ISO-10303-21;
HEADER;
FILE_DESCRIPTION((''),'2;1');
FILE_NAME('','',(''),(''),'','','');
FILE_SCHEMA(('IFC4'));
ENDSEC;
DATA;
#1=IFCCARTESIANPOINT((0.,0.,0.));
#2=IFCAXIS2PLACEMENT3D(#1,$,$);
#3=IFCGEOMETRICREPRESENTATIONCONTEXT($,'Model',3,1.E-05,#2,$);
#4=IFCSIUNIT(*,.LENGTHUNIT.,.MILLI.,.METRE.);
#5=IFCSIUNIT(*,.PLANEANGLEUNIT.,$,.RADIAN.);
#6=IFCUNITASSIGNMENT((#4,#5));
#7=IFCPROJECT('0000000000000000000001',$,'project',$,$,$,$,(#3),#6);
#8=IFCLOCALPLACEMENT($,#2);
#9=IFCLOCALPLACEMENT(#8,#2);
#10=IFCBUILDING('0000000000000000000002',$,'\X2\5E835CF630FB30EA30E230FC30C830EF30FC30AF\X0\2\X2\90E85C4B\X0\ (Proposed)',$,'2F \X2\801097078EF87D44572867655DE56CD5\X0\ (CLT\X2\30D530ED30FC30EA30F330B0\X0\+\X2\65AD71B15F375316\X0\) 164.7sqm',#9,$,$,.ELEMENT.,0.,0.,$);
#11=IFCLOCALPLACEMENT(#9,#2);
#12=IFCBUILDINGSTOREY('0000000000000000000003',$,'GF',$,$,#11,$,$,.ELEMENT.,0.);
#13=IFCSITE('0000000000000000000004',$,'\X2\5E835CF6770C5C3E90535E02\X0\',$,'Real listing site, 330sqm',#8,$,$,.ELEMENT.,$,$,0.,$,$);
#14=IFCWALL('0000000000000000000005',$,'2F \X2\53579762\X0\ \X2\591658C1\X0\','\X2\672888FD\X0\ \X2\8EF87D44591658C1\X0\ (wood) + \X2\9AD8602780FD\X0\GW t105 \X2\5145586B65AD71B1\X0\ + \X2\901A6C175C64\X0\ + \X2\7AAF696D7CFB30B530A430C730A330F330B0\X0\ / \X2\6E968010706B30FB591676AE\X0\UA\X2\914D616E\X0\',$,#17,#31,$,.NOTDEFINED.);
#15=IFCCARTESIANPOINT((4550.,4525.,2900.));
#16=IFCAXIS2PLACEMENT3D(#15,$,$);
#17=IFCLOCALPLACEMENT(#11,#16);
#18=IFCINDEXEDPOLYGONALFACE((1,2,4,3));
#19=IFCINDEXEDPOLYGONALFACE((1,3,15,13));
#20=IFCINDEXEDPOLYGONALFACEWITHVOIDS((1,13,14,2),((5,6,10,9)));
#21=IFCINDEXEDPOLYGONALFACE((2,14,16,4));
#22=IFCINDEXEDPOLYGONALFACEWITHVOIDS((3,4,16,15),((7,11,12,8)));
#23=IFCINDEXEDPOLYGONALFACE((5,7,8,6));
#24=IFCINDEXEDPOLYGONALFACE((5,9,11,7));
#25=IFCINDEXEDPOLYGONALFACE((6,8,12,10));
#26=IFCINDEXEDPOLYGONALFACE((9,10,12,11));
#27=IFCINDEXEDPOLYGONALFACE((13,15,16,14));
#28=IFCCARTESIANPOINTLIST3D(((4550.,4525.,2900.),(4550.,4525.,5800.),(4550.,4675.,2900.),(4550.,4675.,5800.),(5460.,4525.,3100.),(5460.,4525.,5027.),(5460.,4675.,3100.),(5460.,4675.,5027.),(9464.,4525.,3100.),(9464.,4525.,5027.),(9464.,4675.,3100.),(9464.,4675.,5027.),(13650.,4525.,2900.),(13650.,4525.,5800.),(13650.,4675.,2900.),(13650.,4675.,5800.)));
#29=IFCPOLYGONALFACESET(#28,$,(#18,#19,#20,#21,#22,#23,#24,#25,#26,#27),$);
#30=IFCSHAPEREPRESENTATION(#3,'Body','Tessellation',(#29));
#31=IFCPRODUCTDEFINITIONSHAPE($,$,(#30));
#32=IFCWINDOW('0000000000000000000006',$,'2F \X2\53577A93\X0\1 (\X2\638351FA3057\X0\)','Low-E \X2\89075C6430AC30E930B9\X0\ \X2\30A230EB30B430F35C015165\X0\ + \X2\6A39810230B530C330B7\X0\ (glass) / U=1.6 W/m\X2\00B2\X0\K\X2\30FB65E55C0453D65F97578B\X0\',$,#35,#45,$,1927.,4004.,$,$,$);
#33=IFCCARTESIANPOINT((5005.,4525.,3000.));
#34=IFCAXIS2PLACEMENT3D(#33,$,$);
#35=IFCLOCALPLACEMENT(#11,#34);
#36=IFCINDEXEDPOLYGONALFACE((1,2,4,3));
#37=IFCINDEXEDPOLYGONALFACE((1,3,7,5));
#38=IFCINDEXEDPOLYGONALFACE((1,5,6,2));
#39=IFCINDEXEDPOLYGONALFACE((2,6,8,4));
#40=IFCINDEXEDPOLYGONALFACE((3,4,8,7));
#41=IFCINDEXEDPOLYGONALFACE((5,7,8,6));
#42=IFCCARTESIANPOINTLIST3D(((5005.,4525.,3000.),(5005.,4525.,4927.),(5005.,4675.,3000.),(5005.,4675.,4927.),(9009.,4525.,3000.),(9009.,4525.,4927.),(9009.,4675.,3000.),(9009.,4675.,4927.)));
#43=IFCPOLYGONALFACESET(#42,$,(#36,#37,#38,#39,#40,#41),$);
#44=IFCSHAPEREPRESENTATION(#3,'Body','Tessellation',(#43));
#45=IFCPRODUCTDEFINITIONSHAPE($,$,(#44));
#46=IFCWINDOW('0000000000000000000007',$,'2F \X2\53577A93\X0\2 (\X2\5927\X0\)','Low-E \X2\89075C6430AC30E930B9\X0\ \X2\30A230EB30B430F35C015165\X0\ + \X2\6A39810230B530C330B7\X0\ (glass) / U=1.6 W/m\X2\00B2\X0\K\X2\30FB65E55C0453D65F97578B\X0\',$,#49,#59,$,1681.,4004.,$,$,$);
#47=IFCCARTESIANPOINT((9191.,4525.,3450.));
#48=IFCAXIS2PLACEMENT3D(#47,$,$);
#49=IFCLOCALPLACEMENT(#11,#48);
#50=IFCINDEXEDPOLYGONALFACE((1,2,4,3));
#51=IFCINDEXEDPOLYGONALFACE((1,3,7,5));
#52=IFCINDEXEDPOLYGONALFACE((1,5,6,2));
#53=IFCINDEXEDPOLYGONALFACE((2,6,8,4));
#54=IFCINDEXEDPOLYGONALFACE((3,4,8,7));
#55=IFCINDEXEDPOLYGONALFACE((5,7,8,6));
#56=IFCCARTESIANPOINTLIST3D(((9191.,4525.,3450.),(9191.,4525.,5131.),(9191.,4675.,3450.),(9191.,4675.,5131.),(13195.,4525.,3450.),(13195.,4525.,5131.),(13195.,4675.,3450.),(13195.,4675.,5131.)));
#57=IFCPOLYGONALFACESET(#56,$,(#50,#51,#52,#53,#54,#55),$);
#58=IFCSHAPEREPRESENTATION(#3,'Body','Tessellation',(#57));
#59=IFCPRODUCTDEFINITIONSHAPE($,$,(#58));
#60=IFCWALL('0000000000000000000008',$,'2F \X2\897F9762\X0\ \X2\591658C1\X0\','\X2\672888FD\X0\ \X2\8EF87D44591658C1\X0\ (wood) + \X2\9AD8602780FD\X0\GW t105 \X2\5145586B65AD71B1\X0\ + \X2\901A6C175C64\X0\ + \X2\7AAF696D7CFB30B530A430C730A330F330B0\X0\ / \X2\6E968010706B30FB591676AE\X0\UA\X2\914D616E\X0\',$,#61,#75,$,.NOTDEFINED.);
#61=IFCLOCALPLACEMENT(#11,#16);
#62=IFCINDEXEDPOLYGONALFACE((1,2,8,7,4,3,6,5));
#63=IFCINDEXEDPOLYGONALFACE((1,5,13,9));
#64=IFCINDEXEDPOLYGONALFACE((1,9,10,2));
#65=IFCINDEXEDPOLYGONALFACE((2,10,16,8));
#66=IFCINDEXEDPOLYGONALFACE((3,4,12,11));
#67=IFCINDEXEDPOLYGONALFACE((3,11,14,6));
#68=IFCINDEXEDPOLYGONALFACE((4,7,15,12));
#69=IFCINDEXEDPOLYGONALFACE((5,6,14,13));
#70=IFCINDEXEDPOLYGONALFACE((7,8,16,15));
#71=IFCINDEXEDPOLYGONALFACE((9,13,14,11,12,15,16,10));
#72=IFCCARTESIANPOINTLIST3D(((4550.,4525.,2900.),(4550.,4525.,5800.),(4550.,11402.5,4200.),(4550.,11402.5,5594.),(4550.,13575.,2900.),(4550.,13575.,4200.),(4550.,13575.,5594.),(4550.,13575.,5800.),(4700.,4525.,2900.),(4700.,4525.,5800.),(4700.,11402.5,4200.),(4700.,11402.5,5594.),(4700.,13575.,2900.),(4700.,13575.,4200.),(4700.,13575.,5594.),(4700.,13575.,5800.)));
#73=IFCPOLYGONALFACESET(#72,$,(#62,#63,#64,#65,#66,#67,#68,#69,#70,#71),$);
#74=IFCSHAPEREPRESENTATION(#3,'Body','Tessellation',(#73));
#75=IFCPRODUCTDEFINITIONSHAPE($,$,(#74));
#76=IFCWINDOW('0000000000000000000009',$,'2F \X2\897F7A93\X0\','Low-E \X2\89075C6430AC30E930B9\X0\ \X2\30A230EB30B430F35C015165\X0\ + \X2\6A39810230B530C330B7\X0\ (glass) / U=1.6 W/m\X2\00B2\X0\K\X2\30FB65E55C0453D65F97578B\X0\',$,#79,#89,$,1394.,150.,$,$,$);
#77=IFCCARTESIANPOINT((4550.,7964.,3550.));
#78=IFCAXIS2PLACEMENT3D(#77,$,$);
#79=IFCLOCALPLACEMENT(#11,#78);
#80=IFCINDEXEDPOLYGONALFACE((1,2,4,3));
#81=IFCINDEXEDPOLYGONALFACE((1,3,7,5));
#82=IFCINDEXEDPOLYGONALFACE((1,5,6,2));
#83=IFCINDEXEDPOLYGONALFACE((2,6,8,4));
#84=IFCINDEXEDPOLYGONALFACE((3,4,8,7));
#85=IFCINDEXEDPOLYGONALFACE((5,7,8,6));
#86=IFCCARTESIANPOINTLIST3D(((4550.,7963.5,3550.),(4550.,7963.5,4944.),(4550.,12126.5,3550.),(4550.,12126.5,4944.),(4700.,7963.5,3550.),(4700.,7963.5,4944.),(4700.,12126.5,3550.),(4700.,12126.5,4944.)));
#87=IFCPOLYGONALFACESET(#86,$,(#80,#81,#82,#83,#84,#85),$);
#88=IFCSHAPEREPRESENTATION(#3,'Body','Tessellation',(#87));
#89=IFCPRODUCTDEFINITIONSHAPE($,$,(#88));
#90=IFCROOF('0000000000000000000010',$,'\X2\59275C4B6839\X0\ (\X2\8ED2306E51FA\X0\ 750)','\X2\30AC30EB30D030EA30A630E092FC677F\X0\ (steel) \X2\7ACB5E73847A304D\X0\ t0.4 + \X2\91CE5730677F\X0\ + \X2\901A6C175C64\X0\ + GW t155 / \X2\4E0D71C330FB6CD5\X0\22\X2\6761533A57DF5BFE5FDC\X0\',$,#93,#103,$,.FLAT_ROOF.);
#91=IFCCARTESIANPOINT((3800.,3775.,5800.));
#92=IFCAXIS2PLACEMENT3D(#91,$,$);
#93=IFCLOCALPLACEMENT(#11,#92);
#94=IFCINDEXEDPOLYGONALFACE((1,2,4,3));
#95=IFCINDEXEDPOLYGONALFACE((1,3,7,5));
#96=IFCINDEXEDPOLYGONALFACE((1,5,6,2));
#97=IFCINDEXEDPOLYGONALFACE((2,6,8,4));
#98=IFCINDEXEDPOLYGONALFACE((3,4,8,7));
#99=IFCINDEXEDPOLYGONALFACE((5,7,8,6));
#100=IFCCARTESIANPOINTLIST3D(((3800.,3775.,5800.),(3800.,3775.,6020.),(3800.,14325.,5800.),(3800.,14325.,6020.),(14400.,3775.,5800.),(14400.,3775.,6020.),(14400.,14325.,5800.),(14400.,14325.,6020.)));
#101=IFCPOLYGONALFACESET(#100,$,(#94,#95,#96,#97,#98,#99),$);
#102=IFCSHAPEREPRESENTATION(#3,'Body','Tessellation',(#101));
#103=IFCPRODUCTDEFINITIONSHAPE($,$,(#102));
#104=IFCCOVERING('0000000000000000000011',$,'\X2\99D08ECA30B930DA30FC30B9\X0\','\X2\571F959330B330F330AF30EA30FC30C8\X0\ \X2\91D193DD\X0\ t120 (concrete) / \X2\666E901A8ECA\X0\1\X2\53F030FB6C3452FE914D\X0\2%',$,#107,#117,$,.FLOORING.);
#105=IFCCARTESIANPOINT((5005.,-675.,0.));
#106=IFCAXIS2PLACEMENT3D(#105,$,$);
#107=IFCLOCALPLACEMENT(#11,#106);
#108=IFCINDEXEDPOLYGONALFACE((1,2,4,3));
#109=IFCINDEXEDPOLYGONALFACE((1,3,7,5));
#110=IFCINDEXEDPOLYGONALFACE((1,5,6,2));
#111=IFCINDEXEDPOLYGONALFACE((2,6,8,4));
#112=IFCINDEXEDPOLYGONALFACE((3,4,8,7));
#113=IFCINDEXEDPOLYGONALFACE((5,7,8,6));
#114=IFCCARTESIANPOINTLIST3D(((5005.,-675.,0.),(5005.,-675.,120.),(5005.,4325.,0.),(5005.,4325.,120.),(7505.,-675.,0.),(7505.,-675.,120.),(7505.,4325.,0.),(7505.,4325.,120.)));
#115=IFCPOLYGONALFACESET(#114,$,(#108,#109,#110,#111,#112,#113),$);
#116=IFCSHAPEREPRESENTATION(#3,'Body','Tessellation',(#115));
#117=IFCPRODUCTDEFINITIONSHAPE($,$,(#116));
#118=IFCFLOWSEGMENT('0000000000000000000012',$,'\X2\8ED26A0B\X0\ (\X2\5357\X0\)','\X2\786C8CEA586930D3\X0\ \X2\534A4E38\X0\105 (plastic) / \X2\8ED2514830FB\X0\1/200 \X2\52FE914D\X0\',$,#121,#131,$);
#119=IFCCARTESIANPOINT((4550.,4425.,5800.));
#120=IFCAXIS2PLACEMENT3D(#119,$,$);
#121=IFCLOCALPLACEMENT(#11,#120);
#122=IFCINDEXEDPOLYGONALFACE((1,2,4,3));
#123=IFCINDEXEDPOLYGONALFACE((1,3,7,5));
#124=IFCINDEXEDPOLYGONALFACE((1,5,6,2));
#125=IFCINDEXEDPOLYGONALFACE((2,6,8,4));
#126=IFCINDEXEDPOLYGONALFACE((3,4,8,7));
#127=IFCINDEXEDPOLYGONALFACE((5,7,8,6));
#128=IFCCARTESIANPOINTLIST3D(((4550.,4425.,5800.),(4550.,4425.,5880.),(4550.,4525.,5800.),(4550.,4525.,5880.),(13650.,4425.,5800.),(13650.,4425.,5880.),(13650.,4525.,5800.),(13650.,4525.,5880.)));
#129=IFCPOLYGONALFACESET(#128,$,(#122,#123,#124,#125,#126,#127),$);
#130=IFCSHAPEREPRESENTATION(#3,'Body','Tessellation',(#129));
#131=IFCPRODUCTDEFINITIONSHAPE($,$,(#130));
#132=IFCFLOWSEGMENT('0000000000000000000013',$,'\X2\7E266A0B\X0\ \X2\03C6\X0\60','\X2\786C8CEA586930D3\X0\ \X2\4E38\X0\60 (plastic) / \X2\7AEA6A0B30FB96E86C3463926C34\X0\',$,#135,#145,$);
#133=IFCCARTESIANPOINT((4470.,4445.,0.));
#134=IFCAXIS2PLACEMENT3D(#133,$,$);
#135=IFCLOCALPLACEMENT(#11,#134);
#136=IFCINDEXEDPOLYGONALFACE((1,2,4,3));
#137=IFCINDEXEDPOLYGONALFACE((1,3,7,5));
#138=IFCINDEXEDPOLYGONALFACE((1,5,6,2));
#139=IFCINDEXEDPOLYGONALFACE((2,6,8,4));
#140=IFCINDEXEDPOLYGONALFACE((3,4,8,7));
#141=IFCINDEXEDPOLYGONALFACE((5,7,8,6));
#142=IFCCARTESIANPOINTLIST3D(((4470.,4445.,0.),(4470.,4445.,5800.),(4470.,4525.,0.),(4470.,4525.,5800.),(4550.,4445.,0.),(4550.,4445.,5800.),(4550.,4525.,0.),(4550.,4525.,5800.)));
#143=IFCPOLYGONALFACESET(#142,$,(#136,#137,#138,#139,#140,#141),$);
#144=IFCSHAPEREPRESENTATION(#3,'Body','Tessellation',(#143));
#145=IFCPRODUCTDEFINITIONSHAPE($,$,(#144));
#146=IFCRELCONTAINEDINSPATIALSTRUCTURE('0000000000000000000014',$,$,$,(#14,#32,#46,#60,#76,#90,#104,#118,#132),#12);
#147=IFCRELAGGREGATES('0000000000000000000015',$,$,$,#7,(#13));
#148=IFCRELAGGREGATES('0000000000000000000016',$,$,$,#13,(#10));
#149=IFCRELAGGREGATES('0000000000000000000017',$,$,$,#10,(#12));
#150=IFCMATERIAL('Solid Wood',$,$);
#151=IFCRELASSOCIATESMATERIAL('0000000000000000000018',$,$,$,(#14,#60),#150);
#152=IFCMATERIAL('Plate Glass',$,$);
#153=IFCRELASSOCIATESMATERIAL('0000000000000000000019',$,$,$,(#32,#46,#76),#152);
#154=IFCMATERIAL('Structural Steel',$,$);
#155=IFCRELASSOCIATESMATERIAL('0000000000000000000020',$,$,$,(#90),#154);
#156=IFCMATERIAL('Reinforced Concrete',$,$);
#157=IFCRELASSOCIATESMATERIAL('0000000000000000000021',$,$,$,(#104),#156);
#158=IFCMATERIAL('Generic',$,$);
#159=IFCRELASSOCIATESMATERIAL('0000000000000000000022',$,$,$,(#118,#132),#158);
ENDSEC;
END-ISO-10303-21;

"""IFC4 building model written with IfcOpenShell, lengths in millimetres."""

from ifc_helpers import new_model, si_unit, frame, frame_2d, origin, place, context, project, spatial, rectangle, extrude, material, element, fill, save


model = new_model("IFC4")

# Units and contexts
model_context = context("Model", 3, precision=1e-05, world=origin())
ifc_project = project(units=[si_unit("LENGTHUNIT", "METRE", prefix="MILLI"), si_unit("PLANEANGLEUNIT", "RADIAN")], contexts=[model_context])

# Site, building, storey
site_placement = place(None, origin())
site = spatial("IfcSite", under=ifc_project, at=site_placement, Name="広島県尾道市", ObjectType="Real listing site, 330sqm", CompositionType="ELEMENT", RefElevation=0.0)
building_placement = place(site_placement, origin())
building = spatial("IfcBuilding", under=site, at=building_placement, Name="広島・リモートワーク2部屋 (Proposed)", ObjectType="2F 耐震軸組在来工法 (CLTフローリング+断熱強化) 164.7sqm", CompositionType="ELEMENT", ElevationOfRefHeight=0.0, ElevationOfTerrain=0.0)
storey_placement = place(building_placement, origin())
storey = spatial("IfcBuildingStorey", under=building, at=storey_placement, Name="GF", CompositionType="ELEMENT", Elevation=0.0)

# Shared definitions
ifc_material_1 = material(Name="Solid Wood")

# Shared definitions
ifc_material_2 = material(Name="Reinforced Concrete")

# Shared definitions
ifc_material_3 = material(Name="Plate Glass")

# Wall, openings, windows
wall_1_placement = place(storey_placement, frame((4550.0, 4525.0, 2900.0)))
wall_1 = element("IfcWall", 1, at=wall_1_placement, inside=storey, material=ifc_material_1, Name="2F 南面 外壁", Description="木製 軸組外壁 (wood) + 高性能GW t105 充填断熱 + 通気層 + 窯業系サイディング / 準耐火・外皮UA配慮", PredefinedType="NOTDEFINED", context=model_context, shape_type="SweptSolid", body=[
    extrude(rectangle(XDim=9100.0, YDim=150.0, at=frame_2d((4550.0, 75.0))), frame((4550.0, 4525.0, 2900.0)), (0.0, 0.0, 1.0), 2900.0),
])
opening_1_placement = place(storey_placement, frame((5005.0, 4525.0, 3000.0)))
opening_1 = element("IfcOpeningElement", 2, at=opening_1_placement, cuts=wall_1, PredefinedType="NOTDEFINED", context=model_context, shape_type="SweptSolid", body=[
    extrude(rectangle(XDim=4004.0, YDim=150.0, at=frame_2d((2002.0, 75.0))), frame((5005.0, 4525.0, 3000.0)), (0.0, 0.0, 1.0), 1927.0),
])
opening_2_placement = place(storey_placement, frame((9191.0, 4525.0, 3450.0)))
opening_2 = element("IfcOpeningElement", 3, at=opening_2_placement, cuts=wall_1, PredefinedType="NOTDEFINED", context=model_context, shape_type="SweptSolid", body=[
    extrude(rectangle(XDim=4004.0, YDim=150.0, at=frame_2d((2002.0, 75.0))), frame((9191.0, 4525.0, 3450.0)), (0.0, 0.0, 1.0), 1681.0),
])
window_1_placement = place(storey_placement, frame((5005.0, 4525.0, 3000.0)))
window_1 = element("IfcWindow", 4, at=window_1_placement, inside=storey, material=ifc_material_3, Name="2F 南窓1 (掃出し)", Description="Low-E 複層ガラス アルゴン封入 + 樹脂サッシ (glass) / U=1.6 W/m²K・日射取得型", OverallHeight=1927.0, OverallWidth=4004.0, context=model_context, shape_type="SweptSolid", body=[
    extrude(rectangle(XDim=4004.0, YDim=150.0, at=frame_2d((2002.0, 75.0))), frame((5005.0, 4525.0, 3000.0)), (0.0, 0.0, 1.0), 1927.0),
])
fill(opening_1, window_1)
window_2_placement = place(storey_placement, frame((9191.0, 4525.0, 3450.0)))
window_2 = element("IfcWindow", 5, at=window_2_placement, inside=storey, material=ifc_material_3, Name="2F 南窓2 (大)", Description="Low-E 複層ガラス アルゴン封入 + 樹脂サッシ (glass) / U=1.6 W/m²K・日射取得型", OverallHeight=1681.0, OverallWidth=4004.0, context=model_context, shape_type="SweptSolid", body=[
    extrude(rectangle(XDim=4004.0, YDim=150.0, at=frame_2d((2002.0, 75.0))), frame((9191.0, 4525.0, 3450.0)), (0.0, 0.0, 1.0), 1681.0),
])
fill(opening_2, window_2)

# Wall, opening, window
wall_2_placement = place(storey_placement, frame((4550.0, 4525.0, 2900.0)))
wall_2 = element("IfcWall", 6, at=wall_2_placement, inside=storey, material=ifc_material_1, Name="2F 西面 外壁", Description="木製 軸組外壁 (wood) + 高性能GW t105 充填断熱 + 通気層 + 窯業系サイディング / 準耐火・外皮UA配慮", PredefinedType="NOTDEFINED", context=model_context, shape_type="SweptSolid", body=[
    extrude(rectangle(XDim=150.0, YDim=9050.0, at=frame_2d((75.0, 4525.0))), frame((4550.0, 4525.0, 2900.0)), (0.0, 0.0, 1.0), 2900.0),
])
opening_3_placement = place(storey_placement, frame((4550.0, 7964.0, 3550.0)))
opening_3 = element("IfcOpeningElement", 7, at=opening_3_placement, cuts=wall_2, PredefinedType="NOTDEFINED", context=model_context, shape_type="SweptSolid", body=[
    extrude(rectangle(XDim=150.0, YDim=4163.0, at=frame_2d((75.0, 2081.0))), frame((4550.0, 7964.0, 3550.0)), (0.0, 0.0, 1.0), 1394.0),
])
window_3_placement = place(storey_placement, frame((4550.0, 7964.0, 3550.0)))
window_3 = element("IfcWindow", 8, at=window_3_placement, inside=storey, material=ifc_material_3, Name="2F 西窓", Description="Low-E 複層ガラス アルゴン封入 + 樹脂サッシ (glass) / U=1.6 W/m²K・日射取得型", OverallHeight=1394.0, OverallWidth=150.0, context=model_context, shape_type="SweptSolid", body=[
    extrude(rectangle(XDim=150.0, YDim=4163.0, at=frame_2d((75.0, 2081.0))), frame((4550.0, 7964.0, 3550.0)), (0.0, 0.0, 1.0), 1394.0),
])
fill(opening_3, window_3)

# Roof
ifc_material_4 = material(Name="Structural Steel")
roof_placement = place(storey_placement, frame((3800.0, 3775.0, 5800.0)))
element("IfcRoof", 9, at=roof_placement, inside=storey, material=ifc_material_4, Name="大屋根 (軒の出 750)", Description="ガルバリウム鋼板 (steel) 立平葺き t0.4 + 野地板 + 通気層 + GW t155 / 不燃・法22条区域対応", PredefinedType="FLAT_ROOF", context=model_context, shape_type="SweptSolid", body=[
    extrude(rectangle(XDim=10600.0, YDim=10550.0, at=frame_2d((5300.0, 5275.0))), frame((3800.0, 3775.0, 5800.0)), (0.0, 0.0, 1.0), 220.0),
])

# Covering
covering_placement = place(storey_placement, frame((5005.0, -675.0, 0.0)))
element("IfcCovering", 10, at=covering_placement, inside=storey, material=ifc_material_2, Name="駐車スペース", Description="土間コンクリート 金鏝 t120 (concrete) / 普通車1台・水勾配2%", PredefinedType="FLOORING", context=model_context, shape_type="SweptSolid", body=[
    extrude(rectangle(XDim=2500.0, YDim=5000.0, at=frame_2d((1250.0, 2500.0))), frame((5005.0, -675.0, 0.0)), (0.0, 0.0, 1.0), 120.0),
])

# Flow segments
ifc_material_5 = material(Name="Generic")
flow_segment_1_placement = place(storey_placement, frame((4550.0, 4425.0, 5800.0)))
element("IfcFlowSegment", 11, at=flow_segment_1_placement, inside=storey, material=ifc_material_5, Name="軒樋 (南)", Description="硬質塩ビ 半丸105 (plastic) / 軒先・1/200 勾配", context=model_context, shape_type="SweptSolid", body=[
    extrude(rectangle(XDim=9100.0, YDim=100.0, at=frame_2d((4550.0, 50.0))), frame((4550.0, 4425.0, 5800.0)), (0.0, 0.0, 1.0), 80.0),
])
flow_segment_2_placement = place(storey_placement, frame((4470.0, 4445.0, 0.0)))
element("IfcFlowSegment", 12, at=flow_segment_2_placement, inside=storey, material=ifc_material_5, Name="縦樋 φ60", Description="硬質塩ビ 丸60 (plastic) / 竪樋・雨水排水", context=model_context, shape_type="SweptSolid", body=[
    extrude(rectangle(XDim=80.0, YDim=80.0, at=frame_2d((40.0, 40.0))), frame((4470.0, 4445.0, 0.0)), (0.0, 0.0, 1.0), 5800.0),
])

save(model, "model.ifc")
